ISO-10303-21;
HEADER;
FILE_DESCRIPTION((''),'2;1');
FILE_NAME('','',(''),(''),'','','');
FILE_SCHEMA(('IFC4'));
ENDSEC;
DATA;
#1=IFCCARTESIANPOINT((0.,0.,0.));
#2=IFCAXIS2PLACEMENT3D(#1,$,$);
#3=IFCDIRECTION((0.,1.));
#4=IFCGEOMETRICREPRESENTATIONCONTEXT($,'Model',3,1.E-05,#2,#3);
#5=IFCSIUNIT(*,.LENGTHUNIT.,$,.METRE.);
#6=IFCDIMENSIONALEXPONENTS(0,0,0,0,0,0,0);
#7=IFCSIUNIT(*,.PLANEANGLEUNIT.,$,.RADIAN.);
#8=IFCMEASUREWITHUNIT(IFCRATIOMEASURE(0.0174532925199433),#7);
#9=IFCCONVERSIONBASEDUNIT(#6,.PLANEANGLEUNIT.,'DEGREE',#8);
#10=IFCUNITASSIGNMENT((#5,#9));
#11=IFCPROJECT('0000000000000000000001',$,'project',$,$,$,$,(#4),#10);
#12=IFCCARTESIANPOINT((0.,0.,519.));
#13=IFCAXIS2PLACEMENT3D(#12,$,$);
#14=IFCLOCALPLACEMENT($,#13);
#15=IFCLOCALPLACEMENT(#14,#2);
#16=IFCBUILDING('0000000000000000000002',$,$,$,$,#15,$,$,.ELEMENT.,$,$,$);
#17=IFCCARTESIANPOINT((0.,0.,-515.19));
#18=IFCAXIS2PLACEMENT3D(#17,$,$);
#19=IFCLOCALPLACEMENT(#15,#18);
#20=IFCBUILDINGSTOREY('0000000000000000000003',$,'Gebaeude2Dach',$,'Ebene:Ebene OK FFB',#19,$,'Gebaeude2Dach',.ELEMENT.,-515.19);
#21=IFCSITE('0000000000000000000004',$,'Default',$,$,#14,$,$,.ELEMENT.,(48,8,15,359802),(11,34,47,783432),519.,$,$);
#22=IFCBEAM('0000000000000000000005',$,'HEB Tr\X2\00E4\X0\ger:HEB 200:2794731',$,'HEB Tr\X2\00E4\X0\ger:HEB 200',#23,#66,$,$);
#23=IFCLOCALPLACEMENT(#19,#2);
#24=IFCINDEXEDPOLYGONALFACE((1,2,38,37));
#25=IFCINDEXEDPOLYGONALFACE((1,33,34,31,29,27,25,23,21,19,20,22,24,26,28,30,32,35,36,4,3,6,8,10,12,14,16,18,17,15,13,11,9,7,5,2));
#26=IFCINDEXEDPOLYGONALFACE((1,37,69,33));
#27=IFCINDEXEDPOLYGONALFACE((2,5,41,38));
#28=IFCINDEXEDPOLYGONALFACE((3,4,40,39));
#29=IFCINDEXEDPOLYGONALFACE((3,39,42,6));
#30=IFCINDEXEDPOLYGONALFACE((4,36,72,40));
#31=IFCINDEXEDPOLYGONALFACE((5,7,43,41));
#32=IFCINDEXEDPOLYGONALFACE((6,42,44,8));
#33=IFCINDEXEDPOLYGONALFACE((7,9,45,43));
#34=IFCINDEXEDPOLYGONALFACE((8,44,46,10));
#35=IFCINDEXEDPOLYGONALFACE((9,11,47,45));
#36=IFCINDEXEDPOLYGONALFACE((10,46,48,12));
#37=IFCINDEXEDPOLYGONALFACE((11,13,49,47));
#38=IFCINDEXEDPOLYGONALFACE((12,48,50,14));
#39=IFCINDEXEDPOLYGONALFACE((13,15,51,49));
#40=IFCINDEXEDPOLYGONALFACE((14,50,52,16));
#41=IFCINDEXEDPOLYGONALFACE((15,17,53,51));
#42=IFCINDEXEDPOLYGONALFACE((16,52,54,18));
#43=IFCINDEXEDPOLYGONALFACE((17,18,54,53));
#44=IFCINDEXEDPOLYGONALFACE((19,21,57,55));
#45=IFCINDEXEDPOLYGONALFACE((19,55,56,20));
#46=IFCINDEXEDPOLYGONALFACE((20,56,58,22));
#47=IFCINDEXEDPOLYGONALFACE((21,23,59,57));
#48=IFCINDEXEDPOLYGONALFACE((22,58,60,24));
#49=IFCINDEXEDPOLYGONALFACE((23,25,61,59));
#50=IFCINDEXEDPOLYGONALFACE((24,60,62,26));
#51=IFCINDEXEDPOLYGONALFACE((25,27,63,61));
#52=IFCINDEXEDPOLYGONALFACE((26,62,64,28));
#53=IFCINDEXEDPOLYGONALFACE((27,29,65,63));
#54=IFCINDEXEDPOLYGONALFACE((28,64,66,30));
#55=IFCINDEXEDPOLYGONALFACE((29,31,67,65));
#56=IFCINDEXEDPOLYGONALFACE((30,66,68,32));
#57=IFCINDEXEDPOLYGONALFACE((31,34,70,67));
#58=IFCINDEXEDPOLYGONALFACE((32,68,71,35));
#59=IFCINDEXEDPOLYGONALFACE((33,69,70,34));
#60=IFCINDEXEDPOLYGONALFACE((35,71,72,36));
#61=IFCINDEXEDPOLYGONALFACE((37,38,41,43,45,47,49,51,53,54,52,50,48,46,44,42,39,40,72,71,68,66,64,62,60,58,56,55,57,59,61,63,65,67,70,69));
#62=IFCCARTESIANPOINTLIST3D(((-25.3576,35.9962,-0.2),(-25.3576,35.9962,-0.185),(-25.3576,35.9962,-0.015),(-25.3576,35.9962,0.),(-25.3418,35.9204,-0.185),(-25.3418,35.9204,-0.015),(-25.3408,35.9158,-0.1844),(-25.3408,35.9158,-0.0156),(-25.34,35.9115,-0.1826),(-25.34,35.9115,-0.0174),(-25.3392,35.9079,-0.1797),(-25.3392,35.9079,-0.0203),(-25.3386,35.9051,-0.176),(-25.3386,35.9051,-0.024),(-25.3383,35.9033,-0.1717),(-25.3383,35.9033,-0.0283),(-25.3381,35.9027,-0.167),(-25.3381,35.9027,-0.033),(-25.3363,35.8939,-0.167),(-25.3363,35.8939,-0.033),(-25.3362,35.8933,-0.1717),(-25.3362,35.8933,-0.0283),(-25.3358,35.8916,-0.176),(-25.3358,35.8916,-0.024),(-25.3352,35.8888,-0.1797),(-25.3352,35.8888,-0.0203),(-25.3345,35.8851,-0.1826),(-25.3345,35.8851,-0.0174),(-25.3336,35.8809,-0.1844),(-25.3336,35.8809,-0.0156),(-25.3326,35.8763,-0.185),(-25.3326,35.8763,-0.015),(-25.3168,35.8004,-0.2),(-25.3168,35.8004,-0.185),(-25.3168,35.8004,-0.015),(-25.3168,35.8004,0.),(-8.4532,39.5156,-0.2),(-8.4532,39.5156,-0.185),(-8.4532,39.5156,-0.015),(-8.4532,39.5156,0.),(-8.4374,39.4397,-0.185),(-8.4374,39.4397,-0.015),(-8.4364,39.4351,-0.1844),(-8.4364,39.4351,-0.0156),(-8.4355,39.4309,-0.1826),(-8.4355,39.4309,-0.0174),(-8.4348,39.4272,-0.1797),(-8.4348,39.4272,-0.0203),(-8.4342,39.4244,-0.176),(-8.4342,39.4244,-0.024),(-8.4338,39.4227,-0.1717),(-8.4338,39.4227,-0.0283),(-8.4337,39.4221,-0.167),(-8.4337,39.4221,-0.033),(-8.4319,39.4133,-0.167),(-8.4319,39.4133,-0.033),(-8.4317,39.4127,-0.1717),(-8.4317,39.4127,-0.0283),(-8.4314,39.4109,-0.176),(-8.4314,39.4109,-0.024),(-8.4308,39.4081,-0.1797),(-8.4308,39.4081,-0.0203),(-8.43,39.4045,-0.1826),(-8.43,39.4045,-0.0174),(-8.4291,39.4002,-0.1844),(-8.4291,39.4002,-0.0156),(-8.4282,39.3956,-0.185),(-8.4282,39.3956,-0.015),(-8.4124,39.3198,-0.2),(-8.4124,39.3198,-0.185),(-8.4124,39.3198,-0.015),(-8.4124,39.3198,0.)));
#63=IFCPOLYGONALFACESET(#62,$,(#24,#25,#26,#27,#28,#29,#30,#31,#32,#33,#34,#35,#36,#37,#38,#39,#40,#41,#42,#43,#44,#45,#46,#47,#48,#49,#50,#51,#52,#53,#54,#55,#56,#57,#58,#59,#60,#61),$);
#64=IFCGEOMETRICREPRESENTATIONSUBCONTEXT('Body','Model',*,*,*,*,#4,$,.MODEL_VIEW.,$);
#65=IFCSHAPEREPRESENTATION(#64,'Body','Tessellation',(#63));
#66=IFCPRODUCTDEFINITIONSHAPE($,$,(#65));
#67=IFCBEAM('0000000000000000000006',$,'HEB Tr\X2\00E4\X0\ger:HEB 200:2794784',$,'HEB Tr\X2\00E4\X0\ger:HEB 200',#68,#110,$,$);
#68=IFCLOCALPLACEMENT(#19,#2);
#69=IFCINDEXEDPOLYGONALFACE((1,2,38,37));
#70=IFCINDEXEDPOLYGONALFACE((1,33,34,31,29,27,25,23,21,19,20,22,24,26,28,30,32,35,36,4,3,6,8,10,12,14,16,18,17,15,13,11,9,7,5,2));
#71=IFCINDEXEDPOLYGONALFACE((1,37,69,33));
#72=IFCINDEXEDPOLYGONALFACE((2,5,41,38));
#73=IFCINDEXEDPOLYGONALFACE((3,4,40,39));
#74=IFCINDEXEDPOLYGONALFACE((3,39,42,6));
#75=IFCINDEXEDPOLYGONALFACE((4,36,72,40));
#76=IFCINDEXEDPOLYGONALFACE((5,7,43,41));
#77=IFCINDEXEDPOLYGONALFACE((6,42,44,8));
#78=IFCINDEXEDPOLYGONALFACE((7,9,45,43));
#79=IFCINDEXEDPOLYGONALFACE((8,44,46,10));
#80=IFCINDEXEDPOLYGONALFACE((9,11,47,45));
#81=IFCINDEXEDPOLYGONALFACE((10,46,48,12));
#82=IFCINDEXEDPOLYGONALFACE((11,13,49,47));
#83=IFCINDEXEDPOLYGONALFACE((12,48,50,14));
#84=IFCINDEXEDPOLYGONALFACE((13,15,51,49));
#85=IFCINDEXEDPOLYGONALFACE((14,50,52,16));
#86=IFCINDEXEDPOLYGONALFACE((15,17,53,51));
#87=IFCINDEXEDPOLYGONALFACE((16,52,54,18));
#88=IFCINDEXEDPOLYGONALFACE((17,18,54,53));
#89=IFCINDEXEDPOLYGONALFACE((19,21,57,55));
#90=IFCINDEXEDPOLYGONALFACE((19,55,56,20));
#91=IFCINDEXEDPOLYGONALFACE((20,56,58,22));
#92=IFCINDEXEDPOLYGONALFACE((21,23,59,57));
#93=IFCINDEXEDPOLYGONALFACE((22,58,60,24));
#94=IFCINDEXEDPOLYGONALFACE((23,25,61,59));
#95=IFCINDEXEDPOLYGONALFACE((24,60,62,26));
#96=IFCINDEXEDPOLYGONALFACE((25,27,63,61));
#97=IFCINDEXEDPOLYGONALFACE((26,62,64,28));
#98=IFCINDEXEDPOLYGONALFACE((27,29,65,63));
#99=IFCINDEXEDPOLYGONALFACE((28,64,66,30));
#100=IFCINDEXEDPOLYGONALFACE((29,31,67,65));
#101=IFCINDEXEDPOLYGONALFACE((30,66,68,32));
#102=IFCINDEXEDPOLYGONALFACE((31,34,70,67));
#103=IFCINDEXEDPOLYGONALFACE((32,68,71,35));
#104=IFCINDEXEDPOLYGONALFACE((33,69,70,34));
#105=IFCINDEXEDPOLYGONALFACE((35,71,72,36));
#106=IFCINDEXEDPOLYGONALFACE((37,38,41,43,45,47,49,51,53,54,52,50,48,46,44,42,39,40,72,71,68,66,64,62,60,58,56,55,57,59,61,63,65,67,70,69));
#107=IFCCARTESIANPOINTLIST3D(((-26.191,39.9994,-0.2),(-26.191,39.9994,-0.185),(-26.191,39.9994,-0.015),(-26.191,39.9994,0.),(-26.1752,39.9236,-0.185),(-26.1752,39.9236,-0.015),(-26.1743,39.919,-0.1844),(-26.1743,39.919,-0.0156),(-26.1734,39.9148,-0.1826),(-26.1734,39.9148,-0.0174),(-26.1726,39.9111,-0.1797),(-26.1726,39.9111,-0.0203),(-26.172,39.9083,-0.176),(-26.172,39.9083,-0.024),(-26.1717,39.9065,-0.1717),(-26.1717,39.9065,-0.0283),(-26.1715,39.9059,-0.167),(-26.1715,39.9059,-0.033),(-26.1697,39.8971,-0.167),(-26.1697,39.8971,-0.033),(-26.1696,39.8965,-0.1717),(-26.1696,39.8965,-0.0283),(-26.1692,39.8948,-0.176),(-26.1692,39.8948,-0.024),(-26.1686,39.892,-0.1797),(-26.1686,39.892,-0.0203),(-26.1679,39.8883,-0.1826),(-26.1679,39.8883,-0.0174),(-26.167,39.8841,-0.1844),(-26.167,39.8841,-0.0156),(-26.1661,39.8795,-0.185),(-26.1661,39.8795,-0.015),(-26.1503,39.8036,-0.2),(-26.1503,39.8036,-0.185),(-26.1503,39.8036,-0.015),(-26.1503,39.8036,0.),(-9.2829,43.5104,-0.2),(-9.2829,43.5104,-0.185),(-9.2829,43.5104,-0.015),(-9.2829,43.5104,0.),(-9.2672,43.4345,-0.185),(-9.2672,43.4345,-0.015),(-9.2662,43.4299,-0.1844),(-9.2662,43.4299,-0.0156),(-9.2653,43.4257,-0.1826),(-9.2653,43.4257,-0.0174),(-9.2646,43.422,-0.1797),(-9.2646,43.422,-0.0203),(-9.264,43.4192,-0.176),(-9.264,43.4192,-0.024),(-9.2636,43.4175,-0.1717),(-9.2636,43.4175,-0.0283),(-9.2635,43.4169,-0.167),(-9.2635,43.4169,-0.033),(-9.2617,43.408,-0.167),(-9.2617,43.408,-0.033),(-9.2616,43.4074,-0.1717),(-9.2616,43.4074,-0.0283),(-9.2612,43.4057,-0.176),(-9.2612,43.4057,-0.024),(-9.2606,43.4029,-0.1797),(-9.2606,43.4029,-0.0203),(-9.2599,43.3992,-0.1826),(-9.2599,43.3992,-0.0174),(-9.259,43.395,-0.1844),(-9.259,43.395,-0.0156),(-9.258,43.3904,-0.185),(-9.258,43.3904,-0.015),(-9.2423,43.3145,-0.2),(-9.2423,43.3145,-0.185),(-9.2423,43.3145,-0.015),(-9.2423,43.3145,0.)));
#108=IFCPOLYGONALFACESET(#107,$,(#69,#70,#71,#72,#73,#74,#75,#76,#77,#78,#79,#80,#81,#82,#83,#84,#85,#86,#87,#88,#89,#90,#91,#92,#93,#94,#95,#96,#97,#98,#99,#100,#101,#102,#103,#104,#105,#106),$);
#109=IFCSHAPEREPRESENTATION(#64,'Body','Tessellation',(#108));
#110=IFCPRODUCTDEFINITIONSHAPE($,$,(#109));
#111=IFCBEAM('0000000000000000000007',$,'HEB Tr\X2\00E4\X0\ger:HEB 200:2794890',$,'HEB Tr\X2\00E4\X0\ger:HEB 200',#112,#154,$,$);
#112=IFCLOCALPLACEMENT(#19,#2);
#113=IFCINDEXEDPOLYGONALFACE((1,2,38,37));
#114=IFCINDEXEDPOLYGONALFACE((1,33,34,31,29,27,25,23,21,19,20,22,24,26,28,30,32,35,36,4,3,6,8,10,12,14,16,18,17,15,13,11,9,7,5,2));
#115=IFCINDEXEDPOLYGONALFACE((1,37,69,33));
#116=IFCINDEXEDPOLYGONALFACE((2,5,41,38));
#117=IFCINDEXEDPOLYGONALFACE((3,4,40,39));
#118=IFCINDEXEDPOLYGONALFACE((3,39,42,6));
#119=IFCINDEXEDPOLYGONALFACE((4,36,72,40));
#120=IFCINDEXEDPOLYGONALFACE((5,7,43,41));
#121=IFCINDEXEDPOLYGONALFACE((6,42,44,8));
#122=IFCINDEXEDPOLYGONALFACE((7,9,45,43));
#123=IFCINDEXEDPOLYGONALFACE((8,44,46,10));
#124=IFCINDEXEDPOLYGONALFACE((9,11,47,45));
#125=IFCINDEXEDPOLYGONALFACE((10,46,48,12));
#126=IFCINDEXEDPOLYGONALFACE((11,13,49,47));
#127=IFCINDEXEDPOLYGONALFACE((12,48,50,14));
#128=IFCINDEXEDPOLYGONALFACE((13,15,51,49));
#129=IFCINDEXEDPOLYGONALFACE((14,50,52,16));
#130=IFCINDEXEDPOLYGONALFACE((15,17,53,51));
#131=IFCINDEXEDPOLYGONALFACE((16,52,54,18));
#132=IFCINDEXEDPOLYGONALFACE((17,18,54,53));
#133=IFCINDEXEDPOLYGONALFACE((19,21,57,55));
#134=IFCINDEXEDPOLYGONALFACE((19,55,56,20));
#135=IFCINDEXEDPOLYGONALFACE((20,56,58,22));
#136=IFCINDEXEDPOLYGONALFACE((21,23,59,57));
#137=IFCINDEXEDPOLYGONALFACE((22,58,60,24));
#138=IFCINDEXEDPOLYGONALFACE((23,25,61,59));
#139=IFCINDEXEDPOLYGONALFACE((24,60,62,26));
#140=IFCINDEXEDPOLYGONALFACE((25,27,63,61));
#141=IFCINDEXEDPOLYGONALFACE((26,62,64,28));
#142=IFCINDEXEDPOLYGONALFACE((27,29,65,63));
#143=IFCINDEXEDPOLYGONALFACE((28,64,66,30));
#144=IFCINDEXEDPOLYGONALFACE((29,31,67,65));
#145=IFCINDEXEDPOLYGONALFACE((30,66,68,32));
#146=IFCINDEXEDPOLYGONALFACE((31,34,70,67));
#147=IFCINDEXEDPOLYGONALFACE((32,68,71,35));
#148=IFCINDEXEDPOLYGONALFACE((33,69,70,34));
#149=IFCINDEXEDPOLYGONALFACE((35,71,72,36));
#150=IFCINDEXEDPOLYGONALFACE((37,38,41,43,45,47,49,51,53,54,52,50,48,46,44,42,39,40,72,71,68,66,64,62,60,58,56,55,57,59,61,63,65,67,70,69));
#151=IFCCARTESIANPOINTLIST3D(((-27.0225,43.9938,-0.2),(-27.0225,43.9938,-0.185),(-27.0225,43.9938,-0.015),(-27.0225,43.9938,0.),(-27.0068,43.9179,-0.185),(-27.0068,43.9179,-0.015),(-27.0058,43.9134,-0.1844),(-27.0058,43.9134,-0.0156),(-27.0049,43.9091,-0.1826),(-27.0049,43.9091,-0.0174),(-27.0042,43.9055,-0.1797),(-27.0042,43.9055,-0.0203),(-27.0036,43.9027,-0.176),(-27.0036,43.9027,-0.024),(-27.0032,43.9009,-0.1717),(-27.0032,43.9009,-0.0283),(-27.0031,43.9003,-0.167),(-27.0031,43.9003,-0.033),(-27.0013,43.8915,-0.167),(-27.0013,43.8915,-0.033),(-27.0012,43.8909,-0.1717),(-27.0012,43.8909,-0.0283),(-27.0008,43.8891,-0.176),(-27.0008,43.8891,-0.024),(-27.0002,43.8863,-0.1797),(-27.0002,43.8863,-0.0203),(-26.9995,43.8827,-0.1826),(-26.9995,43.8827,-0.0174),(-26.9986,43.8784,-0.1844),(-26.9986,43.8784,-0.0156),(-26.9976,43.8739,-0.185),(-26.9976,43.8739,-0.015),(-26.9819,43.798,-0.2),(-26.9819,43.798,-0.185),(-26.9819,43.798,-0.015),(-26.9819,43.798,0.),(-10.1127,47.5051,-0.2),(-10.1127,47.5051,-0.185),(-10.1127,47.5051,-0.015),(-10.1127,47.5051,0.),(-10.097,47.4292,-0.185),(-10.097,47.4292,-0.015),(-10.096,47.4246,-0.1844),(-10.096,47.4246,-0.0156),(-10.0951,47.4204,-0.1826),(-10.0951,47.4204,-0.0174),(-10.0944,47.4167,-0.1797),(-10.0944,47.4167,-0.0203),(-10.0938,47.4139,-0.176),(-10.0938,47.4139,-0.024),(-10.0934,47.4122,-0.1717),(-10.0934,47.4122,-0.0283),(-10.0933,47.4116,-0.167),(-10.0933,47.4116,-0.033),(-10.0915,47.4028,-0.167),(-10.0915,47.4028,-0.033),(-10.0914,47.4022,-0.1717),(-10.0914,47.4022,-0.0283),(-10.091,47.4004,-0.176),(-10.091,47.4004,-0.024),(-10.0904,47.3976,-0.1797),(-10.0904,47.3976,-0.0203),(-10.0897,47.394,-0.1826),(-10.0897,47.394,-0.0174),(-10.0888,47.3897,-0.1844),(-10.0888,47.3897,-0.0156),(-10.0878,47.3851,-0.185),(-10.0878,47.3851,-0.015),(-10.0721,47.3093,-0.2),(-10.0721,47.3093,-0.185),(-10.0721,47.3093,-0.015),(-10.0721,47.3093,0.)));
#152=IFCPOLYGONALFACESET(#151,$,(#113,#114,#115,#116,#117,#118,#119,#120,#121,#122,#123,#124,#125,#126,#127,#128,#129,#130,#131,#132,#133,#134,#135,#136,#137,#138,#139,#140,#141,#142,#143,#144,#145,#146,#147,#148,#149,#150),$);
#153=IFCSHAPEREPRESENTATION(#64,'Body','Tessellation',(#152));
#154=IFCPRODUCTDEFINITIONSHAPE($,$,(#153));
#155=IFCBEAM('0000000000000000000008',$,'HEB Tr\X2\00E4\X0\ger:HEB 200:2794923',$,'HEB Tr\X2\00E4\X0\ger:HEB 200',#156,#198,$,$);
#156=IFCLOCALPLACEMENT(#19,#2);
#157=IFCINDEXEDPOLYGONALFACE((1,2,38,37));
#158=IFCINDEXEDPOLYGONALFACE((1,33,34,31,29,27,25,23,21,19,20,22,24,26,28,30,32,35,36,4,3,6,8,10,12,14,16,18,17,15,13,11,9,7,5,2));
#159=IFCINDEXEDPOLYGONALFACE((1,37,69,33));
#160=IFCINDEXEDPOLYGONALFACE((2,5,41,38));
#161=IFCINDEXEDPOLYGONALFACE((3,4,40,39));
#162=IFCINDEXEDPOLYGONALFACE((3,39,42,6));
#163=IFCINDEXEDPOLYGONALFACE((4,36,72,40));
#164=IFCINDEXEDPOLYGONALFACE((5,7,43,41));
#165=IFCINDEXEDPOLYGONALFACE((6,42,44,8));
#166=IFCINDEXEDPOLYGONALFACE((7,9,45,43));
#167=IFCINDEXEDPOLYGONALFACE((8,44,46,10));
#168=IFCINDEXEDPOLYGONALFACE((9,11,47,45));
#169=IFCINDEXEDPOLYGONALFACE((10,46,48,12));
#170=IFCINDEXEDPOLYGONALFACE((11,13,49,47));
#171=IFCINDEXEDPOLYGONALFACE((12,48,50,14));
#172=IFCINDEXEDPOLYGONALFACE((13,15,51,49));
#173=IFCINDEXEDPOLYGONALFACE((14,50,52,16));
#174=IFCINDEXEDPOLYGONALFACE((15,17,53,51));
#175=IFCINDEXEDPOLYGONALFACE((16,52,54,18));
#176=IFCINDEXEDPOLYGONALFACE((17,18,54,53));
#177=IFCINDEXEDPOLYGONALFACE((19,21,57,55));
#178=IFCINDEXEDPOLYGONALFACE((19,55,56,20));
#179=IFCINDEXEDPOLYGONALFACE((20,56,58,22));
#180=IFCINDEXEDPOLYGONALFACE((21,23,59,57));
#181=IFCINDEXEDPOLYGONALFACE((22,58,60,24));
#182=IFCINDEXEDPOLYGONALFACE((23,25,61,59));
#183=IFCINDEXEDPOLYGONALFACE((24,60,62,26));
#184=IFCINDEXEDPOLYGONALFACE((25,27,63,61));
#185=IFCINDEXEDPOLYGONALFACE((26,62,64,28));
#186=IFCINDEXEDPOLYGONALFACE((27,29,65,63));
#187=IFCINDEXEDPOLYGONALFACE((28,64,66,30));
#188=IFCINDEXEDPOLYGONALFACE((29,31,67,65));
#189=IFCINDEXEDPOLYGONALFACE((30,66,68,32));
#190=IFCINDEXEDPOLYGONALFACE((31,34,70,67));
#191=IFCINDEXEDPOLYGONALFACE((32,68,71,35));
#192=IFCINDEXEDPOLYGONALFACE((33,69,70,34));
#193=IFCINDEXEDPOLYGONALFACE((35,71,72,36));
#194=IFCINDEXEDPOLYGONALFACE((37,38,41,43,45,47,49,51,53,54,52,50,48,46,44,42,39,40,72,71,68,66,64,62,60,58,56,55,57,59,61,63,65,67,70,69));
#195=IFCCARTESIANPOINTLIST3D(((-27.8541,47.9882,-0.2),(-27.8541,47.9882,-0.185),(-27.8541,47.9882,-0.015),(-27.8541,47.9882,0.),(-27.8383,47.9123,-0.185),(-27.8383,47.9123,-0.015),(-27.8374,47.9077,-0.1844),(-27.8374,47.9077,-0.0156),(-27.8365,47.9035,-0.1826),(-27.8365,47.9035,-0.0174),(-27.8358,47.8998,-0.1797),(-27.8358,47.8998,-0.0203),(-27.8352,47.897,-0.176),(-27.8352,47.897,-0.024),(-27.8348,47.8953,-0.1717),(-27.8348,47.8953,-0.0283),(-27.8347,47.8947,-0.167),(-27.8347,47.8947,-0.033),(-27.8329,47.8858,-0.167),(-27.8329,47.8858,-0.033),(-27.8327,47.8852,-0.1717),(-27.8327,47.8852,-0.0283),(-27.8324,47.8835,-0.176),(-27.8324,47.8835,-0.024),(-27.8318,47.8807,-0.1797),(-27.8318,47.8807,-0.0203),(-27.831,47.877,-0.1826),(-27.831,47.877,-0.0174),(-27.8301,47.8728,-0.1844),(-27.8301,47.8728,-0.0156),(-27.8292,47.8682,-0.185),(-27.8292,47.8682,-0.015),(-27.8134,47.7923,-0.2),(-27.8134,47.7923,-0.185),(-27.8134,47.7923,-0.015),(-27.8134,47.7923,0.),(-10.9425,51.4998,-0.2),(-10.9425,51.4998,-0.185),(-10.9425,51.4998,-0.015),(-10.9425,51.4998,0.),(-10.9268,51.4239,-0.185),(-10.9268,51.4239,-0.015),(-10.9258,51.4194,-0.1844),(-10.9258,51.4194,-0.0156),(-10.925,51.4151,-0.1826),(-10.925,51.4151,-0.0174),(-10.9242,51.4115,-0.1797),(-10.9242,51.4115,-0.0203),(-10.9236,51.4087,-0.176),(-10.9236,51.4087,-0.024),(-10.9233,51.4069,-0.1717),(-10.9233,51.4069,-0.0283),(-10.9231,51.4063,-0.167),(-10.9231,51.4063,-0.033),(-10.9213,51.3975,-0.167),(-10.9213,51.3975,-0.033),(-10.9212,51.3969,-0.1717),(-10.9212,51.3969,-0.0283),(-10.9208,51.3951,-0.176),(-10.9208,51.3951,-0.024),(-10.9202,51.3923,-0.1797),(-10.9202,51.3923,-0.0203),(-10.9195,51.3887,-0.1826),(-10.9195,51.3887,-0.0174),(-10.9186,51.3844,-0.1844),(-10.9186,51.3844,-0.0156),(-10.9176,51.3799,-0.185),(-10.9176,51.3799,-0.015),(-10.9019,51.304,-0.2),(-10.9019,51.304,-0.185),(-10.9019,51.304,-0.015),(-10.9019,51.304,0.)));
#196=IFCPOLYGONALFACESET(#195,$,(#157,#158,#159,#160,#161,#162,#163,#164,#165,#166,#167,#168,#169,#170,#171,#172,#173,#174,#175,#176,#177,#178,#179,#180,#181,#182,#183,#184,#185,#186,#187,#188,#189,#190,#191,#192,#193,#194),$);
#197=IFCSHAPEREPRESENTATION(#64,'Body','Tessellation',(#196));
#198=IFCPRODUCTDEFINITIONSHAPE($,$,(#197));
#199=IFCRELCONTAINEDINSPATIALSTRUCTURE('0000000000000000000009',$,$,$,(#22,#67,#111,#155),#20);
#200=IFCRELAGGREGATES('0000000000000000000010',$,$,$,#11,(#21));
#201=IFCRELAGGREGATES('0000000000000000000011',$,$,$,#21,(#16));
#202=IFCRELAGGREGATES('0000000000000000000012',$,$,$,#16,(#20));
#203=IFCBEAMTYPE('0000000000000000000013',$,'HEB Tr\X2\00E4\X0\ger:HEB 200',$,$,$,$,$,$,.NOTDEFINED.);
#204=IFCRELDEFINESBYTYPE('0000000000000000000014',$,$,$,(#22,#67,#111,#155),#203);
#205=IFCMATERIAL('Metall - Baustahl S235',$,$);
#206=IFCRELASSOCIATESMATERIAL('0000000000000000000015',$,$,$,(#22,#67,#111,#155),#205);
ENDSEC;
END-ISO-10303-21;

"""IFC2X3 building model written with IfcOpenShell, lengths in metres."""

from ifc_helpers import new_model, entity, si_unit, converted_unit, direction, frame, frame_2d, origin, place, context, subcontext, project, spatial, i_section, extrude, material, type_object, element, save


model = new_model("IFC2X3")

# Units and contexts
model_context = context("Model", 3, precision=1e-05, world=origin(), true_north=direction((0.0, 1.0)))
body_context = subcontext(model_context, "Body", "Model", "MODEL_VIEW")
ifc_project = project(units=[si_unit("LENGTHUNIT", "METRE"), converted_unit("PLANEANGLEUNIT", "DEGREE", entity("IfcRatioMeasure", 0.0174532925199433), si_unit("PLANEANGLEUNIT", "RADIAN"), dimensions=[0, 0, 0, 0, 0, 0, 0])], contexts=[model_context])

# Site, building, storey
site_placement = place(None, frame((0.0, 0.0, 519.0)))
site = spatial("IfcSite", under=ifc_project, at=site_placement, Name="Default", CompositionType="ELEMENT", RefLatitude=(48, 8, 15, 359802), RefLongitude=(11, 34, 47, 783432), RefElevation=519.0)
building_placement = place(site_placement, origin())
building = spatial("IfcBuilding", under=site, at=building_placement, CompositionType="ELEMENT")
storey_placement = place(building_placement, frame((0.0, 0.0, -515.19)))
storey = spatial("IfcBuildingStorey", under=building, at=storey_placement, Name="Gebaeude2Dach", ObjectType="Ebene:Ebene OK FFB", LongName="Gebaeude2Dach", CompositionType="ELEMENT", Elevation=-515.19)

# Beams
ifc_material = material(Name="Metall - Baustahl S235")
beam_type = type_object("IfcBeamType", Name="HEB Träger:HEB 200", PredefinedType="NOTDEFINED")
beam_1_placement = place(storey_placement, frame((-25.4505, 35.8747, 0.0), z_axis=(0.0, 0.0, 1.0), x_axis=(0.979008, 0.20382, 0.0)))
element("IfcBeam", 1, at=beam_1_placement, inside=storey, type_object=beam_type, material=ifc_material, Name="HEB Träger:HEB 200:2794731", ObjectType="HEB Träger:HEB 200", context=body_context, shape_type="SweptSolid", body=[
    extrude(i_section(OverallWidth=0.2, OverallDepth=0.2, WebThickness=0.009, FlangeThickness=0.015, FilletRadius=0.018, at=frame_2d((0.0, 0.0), x_axis=(0.0, 1.0))), frame((0.1157, 0.0, -0.1), z_axis=(1.0, 0.0, 0.0), x_axis=(0.0, 0.0, -1.0)), (0.0, 0.0, 1.0), 17.2669),
])
beam_2_placement = place(storey_placement, frame((-26.284, 39.878, 0.0), z_axis=(0.0, 0.0, 1.0), x_axis=(0.979114, 0.203311, 0.0)))
element("IfcBeam", 2, at=beam_2_placement, inside=storey, type_object=beam_type, material=ifc_material, Name="HEB Träger:HEB 200:2794784", ObjectType="HEB Träger:HEB 200", context=body_context, shape_type="SweptSolid", body=[
    extrude(i_section(OverallWidth=0.2, OverallDepth=0.2, WebThickness=0.009, FlangeThickness=0.015, FilletRadius=0.018, at=frame_2d((0.0, 0.0), x_axis=(0.0, 1.0))), frame((0.1158, 0.0, -0.1), z_axis=(1.0, 0.0, 0.0), x_axis=(0.0, 0.0, -1.0)), (0.0, 0.0, 1.0), 17.2687),
])
beam_3_placement = place(storey_placement, frame((-27.1155, 43.8724, 0.0), z_axis=(0.0, 0.0, 1.0), x_axis=(0.979114, 0.203311, 0.0)))
element("IfcBeam", 3, at=beam_3_placement, inside=storey, type_object=beam_type, material=ifc_material, Name="HEB Träger:HEB 200:2794890", ObjectType="HEB Träger:HEB 200", context=body_context, shape_type="SweptSolid", body=[
    extrude(i_section(OverallWidth=0.2, OverallDepth=0.2, WebThickness=0.009, FlangeThickness=0.015, FilletRadius=0.018, at=frame_2d((0.0, 0.0), x_axis=(0.0, 1.0))), frame((0.1158, 0.0, -0.1), z_axis=(1.0, 0.0, 0.0), x_axis=(0.0, 0.0, -1.0)), (0.0, 0.0, 1.0), 17.2705),
])
beam_4_placement = place(storey_placement, frame((-10.8089, 51.4254, 0.0), z_axis=(0.0, 0.0, 1.0), x_axis=(-0.979114, -0.203311, 0.0)))
element("IfcBeam", 4, at=beam_4_placement, inside=storey, type_object=beam_type, material=ifc_material, Name="HEB Träger:HEB 200:2794923", ObjectType="HEB Träger:HEB 200", context=body_context, shape_type="SweptSolid", body=[
    extrude(i_section(OverallWidth=0.2, OverallDepth=0.2, WebThickness=0.009, FlangeThickness=0.015, FilletRadius=0.018, at=frame_2d((0.0, 0.0), x_axis=(0.0, 1.0))), frame((0.1158, 0.0, -0.1), z_axis=(1.0, 0.0, 0.0), x_axis=(0.0, 0.0, -1.0)), (0.0, 0.0, 1.0), 17.2723),
])

save(model, "model.ifc")
